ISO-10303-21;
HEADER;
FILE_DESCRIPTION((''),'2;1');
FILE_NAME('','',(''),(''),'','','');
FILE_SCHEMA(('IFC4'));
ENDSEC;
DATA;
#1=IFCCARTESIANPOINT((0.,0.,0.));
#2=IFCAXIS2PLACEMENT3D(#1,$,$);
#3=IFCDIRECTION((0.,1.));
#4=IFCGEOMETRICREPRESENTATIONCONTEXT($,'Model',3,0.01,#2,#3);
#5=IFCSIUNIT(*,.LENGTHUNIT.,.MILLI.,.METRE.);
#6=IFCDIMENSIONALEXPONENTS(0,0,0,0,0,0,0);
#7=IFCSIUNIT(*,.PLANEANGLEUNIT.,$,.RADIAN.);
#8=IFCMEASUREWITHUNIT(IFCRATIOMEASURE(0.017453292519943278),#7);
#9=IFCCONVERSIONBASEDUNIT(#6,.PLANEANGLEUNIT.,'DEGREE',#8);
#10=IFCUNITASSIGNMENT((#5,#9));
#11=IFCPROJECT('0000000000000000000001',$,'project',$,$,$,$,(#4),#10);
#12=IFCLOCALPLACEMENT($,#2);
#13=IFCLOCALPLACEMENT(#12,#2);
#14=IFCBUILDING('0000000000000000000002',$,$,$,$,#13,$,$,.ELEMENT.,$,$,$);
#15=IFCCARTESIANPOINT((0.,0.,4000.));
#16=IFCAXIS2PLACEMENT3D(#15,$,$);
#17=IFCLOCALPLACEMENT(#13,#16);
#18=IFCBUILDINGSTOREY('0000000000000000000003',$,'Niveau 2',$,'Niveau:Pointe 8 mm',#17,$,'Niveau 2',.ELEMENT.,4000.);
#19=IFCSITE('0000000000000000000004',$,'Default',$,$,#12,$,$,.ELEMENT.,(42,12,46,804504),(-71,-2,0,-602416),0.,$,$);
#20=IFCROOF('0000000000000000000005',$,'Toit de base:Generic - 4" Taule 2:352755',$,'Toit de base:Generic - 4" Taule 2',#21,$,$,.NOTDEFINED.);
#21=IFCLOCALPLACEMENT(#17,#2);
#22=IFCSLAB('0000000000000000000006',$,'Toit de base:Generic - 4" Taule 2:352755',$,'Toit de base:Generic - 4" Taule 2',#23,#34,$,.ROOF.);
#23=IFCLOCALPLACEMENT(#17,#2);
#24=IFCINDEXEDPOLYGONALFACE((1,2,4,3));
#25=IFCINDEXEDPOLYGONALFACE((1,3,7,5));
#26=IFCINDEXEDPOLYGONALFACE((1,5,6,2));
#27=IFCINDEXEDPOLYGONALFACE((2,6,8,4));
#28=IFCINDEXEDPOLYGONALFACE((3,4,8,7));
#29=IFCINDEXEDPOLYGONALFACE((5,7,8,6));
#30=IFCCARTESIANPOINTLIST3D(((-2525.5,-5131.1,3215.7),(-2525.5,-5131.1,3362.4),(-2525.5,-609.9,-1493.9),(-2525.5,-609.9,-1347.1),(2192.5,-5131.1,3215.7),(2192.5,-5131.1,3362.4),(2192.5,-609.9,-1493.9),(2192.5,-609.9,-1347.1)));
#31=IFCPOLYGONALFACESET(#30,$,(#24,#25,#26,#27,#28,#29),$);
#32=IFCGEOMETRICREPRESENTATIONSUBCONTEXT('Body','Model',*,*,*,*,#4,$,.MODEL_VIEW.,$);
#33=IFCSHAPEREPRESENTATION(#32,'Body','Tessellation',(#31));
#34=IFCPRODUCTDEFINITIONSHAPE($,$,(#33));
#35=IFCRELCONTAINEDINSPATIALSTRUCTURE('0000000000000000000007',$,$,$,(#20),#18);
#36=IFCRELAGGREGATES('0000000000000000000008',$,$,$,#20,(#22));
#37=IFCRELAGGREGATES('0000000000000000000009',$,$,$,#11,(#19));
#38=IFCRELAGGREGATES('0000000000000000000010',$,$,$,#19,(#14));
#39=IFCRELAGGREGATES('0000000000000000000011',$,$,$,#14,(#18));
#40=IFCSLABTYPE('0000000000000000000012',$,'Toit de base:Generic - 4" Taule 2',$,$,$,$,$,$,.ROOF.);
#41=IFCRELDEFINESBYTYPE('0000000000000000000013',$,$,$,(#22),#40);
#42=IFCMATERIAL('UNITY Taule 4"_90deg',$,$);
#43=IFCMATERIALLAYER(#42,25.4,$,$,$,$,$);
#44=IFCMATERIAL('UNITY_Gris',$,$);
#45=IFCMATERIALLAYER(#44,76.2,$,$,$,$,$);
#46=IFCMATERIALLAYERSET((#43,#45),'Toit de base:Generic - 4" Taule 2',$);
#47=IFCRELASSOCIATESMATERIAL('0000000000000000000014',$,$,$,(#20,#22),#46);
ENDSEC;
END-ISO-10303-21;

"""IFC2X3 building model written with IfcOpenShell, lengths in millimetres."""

from ifc_helpers import new_model, entity, si_unit, converted_unit, direction, frame, frame_2d, origin, place, context, subcontext, project, spatial, rectangle, extrude, material, layer, layer_set, type_object, element, aggregate, save


model = new_model("IFC2X3")

# Units and contexts
model_context = context("Model", 3, precision=0.01, world=origin(), true_north=direction((0.0, 1.0)))
body_context = subcontext(model_context, "Body", "Model", "MODEL_VIEW")
ifc_project = project(units=[si_unit("LENGTHUNIT", "METRE", prefix="MILLI"), converted_unit("PLANEANGLEUNIT", "DEGREE", entity("IfcRatioMeasure", 0.017453292519943278), si_unit("PLANEANGLEUNIT", "RADIAN"), dimensions=[0, 0, 0, 0, 0, 0, 0])], contexts=[model_context])

# Site, building, storey
site_placement = place(None, origin())
site = spatial("IfcSite", under=ifc_project, at=site_placement, Name="Default", CompositionType="ELEMENT", RefLatitude=(42, 12, 46, 804504), RefLongitude=(-71, -2, 0, -602416), RefElevation=0.0)
building_placement = place(site_placement, origin())
building = spatial("IfcBuilding", under=site, at=building_placement, CompositionType="ELEMENT")
storey_placement = place(building_placement, frame((0.0, 0.0, 4000.0)))
storey = spatial("IfcBuildingStorey", under=building, at=storey_placement, Name="Niveau 2", ObjectType="Niveau:Pointe 8 mm", LongName="Niveau 2", CompositionType="ELEMENT", Elevation=4000.0)

# Roof, slab
ifc_material_1 = material(Name="UNITY Taule 4\"_90deg")
ifc_layer_1 = layer(ifc_material_1, 25.4)
ifc_material_2 = material(Name="UNITY_Gris")
ifc_layer_2 = layer(ifc_material_2, 76.2)
ifc_layer_set = layer_set([ifc_layer_1, ifc_layer_2], Name="Toit de base:Generic - 4\" Taule 2")
roof_1_placement = place(storey_placement, frame((-2525.5, -5131.1, -1493.9)))
roof_1 = element("IfcRoof", 1, at=roof_1_placement, inside=storey, material=ifc_layer_set, Name="Toit de base:Generic - 4\" Taule 2:352755", ObjectType="Toit de base:Generic - 4\" Taule 2", ShapeType="NOTDEFINED")
slab_type_1 = type_object("IfcSlabType", Name="Toit de base:Generic - 4\" Taule 2", PredefinedType="ROOF")
slab_1_placement = place(roof_1_placement, origin())
slab_1 = element("IfcSlab", 2, at=slab_1_placement, type_object=slab_type_1, material=ifc_layer_set, Name="Toit de base:Generic - 4\" Taule 2:352755", ObjectType="Toit de base:Generic - 4\" Taule 2", PredefinedType="ROOF", context=body_context, shape_type="SweptSolid", body=[
    extrude(rectangle(XDim=4718.1, YDim=6528.5, at=frame_2d((0.0, 0.0), x_axis=(-1.0, 0.0))), frame((2359.0, 2260.6, 2354.8), z_axis=(0.0, 0.721387, 0.692532), x_axis=(1.0, 0.0, 0.0)), (0.0, -0.721387, 0.692532), 146.7),
])
aggregate(roof_1, [slab_1])

save(model, "model.ifc")
